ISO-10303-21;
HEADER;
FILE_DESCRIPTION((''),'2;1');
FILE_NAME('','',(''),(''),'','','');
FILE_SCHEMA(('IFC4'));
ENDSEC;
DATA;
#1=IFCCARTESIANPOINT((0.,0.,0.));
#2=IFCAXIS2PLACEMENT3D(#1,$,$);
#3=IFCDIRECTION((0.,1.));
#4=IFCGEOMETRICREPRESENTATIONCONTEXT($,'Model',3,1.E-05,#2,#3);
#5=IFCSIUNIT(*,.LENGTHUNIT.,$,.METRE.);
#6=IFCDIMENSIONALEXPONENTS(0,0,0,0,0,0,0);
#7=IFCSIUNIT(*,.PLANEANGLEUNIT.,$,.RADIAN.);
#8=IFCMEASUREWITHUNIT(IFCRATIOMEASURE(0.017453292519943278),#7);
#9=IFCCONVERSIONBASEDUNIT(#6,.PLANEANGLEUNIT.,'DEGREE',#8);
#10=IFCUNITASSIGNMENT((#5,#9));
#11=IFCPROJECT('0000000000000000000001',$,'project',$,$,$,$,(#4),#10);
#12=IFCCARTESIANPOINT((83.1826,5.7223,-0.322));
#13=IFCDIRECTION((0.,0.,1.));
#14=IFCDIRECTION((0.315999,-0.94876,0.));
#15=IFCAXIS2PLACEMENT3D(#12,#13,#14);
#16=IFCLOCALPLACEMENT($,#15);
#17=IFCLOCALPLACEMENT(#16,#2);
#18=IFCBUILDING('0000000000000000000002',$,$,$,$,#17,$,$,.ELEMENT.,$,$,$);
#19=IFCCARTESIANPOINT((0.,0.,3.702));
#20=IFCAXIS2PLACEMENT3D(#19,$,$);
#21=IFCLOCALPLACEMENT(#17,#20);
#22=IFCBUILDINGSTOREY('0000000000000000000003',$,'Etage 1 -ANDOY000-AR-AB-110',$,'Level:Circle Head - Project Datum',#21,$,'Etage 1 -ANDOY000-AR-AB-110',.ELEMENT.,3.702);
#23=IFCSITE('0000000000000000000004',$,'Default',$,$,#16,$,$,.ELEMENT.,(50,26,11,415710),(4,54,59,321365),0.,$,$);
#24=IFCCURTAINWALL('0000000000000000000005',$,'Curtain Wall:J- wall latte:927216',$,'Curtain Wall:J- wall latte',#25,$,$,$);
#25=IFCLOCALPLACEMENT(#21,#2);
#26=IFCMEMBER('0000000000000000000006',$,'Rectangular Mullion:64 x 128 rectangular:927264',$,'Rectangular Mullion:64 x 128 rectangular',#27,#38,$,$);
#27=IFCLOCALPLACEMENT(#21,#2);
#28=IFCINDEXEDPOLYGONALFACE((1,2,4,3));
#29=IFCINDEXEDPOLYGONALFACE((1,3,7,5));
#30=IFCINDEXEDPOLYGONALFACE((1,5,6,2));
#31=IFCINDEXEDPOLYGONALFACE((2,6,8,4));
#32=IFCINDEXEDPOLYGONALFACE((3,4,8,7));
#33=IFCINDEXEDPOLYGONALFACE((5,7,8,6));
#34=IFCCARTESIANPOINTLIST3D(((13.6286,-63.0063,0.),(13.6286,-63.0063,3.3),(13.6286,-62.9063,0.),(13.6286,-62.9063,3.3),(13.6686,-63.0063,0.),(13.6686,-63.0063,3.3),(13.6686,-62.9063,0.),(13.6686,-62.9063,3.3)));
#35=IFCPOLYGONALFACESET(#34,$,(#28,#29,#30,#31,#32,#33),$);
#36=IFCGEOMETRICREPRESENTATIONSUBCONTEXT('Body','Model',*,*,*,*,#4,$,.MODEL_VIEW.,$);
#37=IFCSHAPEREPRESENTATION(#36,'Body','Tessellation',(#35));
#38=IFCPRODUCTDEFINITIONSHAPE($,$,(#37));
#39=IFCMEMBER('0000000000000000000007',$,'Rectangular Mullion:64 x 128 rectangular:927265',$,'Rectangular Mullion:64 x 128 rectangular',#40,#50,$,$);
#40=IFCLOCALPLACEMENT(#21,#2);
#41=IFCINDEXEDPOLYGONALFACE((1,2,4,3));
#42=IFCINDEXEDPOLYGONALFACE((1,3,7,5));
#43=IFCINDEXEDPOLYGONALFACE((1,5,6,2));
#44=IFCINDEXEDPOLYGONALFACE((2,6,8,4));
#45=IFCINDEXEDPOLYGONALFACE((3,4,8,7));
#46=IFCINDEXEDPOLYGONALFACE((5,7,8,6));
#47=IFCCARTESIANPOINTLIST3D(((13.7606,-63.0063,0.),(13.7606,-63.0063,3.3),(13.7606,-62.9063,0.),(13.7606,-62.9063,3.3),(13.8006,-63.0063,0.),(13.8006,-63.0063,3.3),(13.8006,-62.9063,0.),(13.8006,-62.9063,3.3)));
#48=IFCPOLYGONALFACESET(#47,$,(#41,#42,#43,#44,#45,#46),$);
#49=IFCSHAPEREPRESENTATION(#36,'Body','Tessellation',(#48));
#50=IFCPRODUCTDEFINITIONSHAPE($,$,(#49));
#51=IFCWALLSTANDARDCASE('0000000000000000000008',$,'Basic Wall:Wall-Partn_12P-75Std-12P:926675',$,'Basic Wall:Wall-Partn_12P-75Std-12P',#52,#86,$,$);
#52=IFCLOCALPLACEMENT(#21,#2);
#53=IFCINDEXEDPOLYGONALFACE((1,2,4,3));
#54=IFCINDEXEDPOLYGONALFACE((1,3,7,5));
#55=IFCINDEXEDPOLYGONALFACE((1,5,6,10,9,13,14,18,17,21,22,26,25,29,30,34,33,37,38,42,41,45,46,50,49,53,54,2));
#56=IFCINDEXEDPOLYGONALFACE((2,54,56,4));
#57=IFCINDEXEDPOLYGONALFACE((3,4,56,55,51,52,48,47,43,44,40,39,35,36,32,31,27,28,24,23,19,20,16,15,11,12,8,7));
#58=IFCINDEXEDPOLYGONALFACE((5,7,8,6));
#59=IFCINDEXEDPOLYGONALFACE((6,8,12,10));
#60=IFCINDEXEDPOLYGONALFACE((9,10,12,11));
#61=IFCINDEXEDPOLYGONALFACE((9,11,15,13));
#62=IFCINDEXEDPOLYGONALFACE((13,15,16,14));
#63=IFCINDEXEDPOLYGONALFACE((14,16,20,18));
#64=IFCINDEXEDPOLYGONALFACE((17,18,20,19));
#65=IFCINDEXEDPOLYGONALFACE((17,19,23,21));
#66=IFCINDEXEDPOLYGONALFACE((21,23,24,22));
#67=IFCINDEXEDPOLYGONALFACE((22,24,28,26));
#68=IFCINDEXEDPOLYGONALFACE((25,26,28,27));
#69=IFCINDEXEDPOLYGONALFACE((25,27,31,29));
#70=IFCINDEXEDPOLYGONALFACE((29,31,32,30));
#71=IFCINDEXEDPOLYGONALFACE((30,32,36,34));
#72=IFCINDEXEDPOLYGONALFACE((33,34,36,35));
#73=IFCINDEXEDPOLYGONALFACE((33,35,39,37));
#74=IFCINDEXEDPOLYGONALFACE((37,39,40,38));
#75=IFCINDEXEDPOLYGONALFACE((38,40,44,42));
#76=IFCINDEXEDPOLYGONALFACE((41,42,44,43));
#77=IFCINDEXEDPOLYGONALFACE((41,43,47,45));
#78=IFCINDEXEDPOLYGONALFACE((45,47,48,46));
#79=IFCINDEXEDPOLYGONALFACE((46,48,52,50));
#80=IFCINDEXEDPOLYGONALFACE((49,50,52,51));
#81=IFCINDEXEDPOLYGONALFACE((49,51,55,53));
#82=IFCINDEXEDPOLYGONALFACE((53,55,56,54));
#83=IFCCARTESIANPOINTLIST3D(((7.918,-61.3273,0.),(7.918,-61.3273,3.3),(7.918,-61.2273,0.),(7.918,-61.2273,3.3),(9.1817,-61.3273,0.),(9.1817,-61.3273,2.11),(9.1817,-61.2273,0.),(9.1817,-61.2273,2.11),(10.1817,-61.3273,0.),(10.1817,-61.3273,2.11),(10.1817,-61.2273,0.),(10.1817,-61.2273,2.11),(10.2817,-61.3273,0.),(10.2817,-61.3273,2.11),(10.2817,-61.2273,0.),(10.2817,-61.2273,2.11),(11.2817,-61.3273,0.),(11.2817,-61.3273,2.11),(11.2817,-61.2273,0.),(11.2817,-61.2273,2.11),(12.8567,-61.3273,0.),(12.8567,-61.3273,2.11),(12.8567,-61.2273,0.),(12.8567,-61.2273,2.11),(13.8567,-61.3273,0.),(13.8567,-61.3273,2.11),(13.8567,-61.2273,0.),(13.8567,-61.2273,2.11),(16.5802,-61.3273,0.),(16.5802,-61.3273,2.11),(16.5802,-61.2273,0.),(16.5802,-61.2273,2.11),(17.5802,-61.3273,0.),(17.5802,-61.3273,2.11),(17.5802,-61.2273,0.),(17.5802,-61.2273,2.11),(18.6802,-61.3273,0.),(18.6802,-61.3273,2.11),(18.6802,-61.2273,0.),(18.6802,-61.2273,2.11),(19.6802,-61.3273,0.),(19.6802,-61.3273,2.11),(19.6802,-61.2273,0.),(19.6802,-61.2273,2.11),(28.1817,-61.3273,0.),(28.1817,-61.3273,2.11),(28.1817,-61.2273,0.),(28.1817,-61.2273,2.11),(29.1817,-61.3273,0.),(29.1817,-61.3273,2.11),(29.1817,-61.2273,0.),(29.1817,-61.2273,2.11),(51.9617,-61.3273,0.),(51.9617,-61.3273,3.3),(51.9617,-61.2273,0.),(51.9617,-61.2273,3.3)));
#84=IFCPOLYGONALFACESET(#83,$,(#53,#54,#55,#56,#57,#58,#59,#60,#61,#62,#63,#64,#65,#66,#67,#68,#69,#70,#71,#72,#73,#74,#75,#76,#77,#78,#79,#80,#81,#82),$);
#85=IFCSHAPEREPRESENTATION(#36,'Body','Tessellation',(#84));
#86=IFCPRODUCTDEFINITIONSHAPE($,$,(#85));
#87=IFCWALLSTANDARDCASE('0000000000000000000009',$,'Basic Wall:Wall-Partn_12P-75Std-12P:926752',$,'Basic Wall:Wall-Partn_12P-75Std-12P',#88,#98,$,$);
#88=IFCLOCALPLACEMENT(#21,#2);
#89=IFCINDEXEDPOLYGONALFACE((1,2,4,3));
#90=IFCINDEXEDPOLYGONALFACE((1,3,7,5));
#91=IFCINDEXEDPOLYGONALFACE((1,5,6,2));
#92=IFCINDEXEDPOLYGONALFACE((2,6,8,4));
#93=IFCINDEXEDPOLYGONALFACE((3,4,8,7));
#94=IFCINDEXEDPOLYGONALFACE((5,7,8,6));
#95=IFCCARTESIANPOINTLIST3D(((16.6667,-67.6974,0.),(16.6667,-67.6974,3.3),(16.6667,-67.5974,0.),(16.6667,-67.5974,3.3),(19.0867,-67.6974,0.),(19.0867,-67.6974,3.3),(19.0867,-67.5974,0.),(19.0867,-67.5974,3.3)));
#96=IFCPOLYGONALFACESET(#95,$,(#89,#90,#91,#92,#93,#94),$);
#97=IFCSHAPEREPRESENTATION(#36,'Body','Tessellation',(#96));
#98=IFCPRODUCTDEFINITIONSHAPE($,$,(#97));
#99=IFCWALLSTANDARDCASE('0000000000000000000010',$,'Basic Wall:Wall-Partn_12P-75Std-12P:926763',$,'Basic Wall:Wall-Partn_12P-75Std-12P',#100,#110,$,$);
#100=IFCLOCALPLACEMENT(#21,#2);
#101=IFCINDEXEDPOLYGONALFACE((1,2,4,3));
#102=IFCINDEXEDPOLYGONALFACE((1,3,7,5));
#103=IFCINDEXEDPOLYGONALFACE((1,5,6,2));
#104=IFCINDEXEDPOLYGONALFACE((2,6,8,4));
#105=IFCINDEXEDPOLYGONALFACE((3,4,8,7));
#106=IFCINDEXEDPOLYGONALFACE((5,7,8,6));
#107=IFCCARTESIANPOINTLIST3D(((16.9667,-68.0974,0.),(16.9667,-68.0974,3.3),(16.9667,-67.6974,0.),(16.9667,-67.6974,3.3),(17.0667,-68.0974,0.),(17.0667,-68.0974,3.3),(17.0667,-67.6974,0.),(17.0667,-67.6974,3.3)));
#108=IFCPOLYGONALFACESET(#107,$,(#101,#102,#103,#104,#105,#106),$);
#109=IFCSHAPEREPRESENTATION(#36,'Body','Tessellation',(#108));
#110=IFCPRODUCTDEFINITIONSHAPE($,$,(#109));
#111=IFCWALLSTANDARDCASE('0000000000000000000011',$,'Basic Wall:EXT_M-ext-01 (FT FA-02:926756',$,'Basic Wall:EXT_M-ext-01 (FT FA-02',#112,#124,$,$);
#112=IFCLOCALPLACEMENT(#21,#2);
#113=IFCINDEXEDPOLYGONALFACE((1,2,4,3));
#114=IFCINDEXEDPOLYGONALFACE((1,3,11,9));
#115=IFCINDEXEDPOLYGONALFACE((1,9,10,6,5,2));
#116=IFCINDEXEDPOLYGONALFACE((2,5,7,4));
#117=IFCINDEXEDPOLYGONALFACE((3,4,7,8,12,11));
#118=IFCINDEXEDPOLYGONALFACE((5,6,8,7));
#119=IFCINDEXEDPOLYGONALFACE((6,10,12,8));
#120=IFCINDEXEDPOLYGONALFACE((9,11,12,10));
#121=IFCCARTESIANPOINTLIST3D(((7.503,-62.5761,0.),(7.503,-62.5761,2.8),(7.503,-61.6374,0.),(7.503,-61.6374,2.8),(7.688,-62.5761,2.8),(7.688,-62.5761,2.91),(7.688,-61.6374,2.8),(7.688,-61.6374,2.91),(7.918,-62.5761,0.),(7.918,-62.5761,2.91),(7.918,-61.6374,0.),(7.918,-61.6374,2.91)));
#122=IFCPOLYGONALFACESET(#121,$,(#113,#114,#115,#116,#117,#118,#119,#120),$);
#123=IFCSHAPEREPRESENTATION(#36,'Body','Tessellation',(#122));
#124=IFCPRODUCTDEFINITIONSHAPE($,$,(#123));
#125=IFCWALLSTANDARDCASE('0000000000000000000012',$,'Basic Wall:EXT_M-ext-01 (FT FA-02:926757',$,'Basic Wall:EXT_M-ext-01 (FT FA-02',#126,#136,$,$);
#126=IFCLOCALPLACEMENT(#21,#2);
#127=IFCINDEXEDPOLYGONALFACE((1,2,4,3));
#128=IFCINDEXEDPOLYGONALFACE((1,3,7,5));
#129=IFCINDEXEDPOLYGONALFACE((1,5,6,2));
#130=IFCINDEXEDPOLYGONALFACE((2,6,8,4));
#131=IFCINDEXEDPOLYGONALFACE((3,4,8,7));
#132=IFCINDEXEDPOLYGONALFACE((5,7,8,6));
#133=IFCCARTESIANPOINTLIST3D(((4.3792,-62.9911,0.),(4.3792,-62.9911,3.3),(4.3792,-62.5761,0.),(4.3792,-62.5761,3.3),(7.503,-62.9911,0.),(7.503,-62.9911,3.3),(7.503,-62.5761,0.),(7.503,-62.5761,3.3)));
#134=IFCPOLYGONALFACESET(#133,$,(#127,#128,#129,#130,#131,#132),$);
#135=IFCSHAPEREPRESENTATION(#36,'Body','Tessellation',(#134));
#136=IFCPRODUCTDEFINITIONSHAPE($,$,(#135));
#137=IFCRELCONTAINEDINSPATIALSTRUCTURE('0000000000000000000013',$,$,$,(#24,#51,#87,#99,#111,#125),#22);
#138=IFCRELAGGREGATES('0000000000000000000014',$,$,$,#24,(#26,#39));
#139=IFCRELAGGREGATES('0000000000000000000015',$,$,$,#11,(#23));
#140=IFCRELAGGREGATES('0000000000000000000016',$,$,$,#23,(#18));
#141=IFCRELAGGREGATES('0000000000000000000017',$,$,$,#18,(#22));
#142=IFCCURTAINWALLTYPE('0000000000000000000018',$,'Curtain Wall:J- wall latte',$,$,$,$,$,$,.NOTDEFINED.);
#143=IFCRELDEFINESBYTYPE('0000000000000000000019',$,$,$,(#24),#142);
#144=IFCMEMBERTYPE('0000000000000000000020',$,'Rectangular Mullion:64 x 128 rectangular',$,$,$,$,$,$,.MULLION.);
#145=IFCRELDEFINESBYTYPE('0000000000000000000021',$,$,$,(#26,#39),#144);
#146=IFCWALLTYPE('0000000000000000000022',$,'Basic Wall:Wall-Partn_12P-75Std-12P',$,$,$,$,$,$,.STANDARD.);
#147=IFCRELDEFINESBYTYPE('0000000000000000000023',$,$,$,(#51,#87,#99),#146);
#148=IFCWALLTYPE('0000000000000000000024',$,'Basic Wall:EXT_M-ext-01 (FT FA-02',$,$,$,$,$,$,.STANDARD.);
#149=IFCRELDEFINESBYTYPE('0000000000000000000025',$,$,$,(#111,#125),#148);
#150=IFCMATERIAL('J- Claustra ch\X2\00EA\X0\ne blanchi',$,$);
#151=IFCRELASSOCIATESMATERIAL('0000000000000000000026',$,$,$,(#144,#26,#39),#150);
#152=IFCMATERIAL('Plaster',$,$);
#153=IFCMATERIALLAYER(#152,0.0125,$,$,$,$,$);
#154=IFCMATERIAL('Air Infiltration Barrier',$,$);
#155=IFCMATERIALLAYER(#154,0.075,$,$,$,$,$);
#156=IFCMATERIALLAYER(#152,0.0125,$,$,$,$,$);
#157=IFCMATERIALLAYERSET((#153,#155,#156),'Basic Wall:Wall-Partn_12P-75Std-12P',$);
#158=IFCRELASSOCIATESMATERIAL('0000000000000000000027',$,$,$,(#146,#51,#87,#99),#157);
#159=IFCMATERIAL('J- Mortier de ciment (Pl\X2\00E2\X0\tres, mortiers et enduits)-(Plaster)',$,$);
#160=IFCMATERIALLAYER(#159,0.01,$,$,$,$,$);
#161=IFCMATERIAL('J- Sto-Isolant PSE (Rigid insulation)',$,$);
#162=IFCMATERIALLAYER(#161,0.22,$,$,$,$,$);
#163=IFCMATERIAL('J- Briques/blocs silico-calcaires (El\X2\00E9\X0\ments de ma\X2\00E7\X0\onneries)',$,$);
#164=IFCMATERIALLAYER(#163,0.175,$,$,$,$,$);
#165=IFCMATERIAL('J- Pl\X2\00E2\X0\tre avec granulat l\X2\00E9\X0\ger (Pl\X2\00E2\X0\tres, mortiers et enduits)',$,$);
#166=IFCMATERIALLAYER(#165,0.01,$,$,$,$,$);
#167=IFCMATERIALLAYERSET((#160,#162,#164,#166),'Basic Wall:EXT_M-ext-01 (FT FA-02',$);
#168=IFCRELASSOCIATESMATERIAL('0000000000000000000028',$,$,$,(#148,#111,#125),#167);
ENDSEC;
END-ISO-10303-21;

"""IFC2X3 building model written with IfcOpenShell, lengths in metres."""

from ifc_helpers import new_model, entity, si_unit, converted_unit, direction, frame, frame_2d, origin, origin_2d_with_axis, place, context, subcontext, project, spatial, polyline, rectangle, extrude, clip, bounded_halfspace, source, transform, mapped, material, layer, layer_set, layer_usage, type_object, type_shapes, element, aggregate, save


model = new_model("IFC2X3")

# Units and contexts
model_context = context("Model", 3, precision=1e-05, world=origin(), true_north=direction((0.0, 1.0)))
body_context = subcontext(model_context, "Body", "Model", "MODEL_VIEW")
ifc_project = project(units=[si_unit("LENGTHUNIT", "METRE"), converted_unit("PLANEANGLEUNIT", "DEGREE", entity("IfcRatioMeasure", 0.017453292519943278), si_unit("PLANEANGLEUNIT", "RADIAN"), dimensions=[0, 0, 0, 0, 0, 0, 0])], contexts=[model_context])

# Site, building, storey
site_placement = place(None, frame((83.1826, 5.7223, -0.322), z_axis=(0.0, 0.0, 1.0), x_axis=(0.315999, -0.94876, 0.0)))
site = spatial("IfcSite", under=ifc_project, at=site_placement, Name="Default", CompositionType="ELEMENT", RefLatitude=(50, 26, 11, 415710), RefLongitude=(4, 54, 59, 321365), RefElevation=0.0)
building_placement = place(site_placement, origin())
building = spatial("IfcBuilding", under=site, at=building_placement, CompositionType="ELEMENT")
storey_placement = place(building_placement, frame((0.0, 0.0, 3.702)))
storey = spatial("IfcBuildingStorey", under=building, at=storey_placement, Name="Etage 1 -ANDOY000-AR-AB-110", ObjectType="Level:Circle Head - Project Datum", LongName="Etage 1 -ANDOY000-AR-AB-110", CompositionType="ELEMENT", Elevation=3.702)

# Curtain wall, members
curtain_wall_type = type_object("IfcCurtainWallType", Name="Curtain Wall:J- wall latte", PredefinedType="NOTDEFINED")
curtain_wall_placement = place(storey_placement, frame((0.0, 0.0, -3.702)))
curtain_wall = element("IfcCurtainWall", 1, at=curtain_wall_placement, inside=storey, type_object=curtain_wall_type, Name="Curtain Wall:J- wall latte:927216", ObjectType="Curtain Wall:J- wall latte")
ifc_material_1 = material(Name="J- Claustra chêne blanchi")
member_type = type_object("IfcMemberType", Name="Rectangular Mullion:64 x 128 rectangular", PredefinedType="MULLION", material=ifc_material_1)
shared_shape_1 = source(origin(), body_context, "Body", "SweptSolid", [
    extrude(rectangle(XDim=0.1, YDim=0.04, at=origin_2d_with_axis()), frame((0.0, 0.0, -3.3), z_axis=(0.0, 0.0, 1.0), x_axis=(0.0, -1.0, 0.0)), (0.0, 0.0, 1.0), 3.3),
])
type_shapes(member_type, [shared_shape_1])
member_1_placement = place(curtain_wall_placement, frame((13.6486, -62.9563, 3.702), z_axis=(0.0, 0.0, -1.0), x_axis=(1.0, 0.0, 0.0)))
member_1 = element("IfcMember", 2, at=member_1_placement, type_object=member_type, material=ifc_material_1, Name="Rectangular Mullion:64 x 128 rectangular:927264", ObjectType="Rectangular Mullion:64 x 128 rectangular", context=body_context, shape_type="MappedRepresentation", body=[
    mapped(shared_shape_1, transform((0.0, 0.0, 0.0), scale=1.0)),
])
member_2_placement = place(curtain_wall_placement, frame((13.7806, -62.9563, 3.702), z_axis=(0.0, 0.0, -1.0), x_axis=(1.0, 0.0, 0.0)))
member_2 = element("IfcMember", 3, at=member_2_placement, type_object=member_type, material=ifc_material_1, Name="Rectangular Mullion:64 x 128 rectangular:927265", ObjectType="Rectangular Mullion:64 x 128 rectangular", context=body_context, shape_type="MappedRepresentation", body=[
    mapped(shared_shape_1, transform((0.0, 0.0, 0.0), scale=1.0)),
])
aggregate(curtain_wall, [member_1, member_2])

# Wall, openings
ifc_material_2 = material(Name="Plaster")
ifc_layer_1 = layer(ifc_material_2, 0.0125)
ifc_material_3 = material(Name="Air Infiltration Barrier")
ifc_layer_2 = layer(ifc_material_3, 0.075)
ifc_layer_3 = layer(ifc_material_2, 0.0125)
ifc_layer_set_1 = layer_set([ifc_layer_1, ifc_layer_2, ifc_layer_3], Name="Basic Wall:Wall-Partn_12P-75Std-12P")
ifc_layer_usage_1 = layer_usage(ifc_layer_set_1, "AXIS2", "NEGATIVE", 0.05)
wall_type_1 = type_object("IfcWallType", Name="Basic Wall:Wall-Partn_12P-75Std-12P", PredefinedType="STANDARD", material=ifc_layer_set_1)
wall_1_placement = place(storey_placement, frame((7.918, -61.2773, 0.0)))
wall_1 = element("IfcWallStandardCase", 4, at=wall_1_placement, inside=storey, type_object=wall_type_1, material=ifc_layer_usage_1, Name="Basic Wall:Wall-Partn_12P-75Std-12P:926675", ObjectType="Basic Wall:Wall-Partn_12P-75Std-12P", context=body_context, shape_type="SweptSolid", body=[
    extrude(rectangle(XDim=44.0438, YDim=0.1, at=frame_2d((22.0219, 0.0), x_axis=(1.0, 0.0))), origin(), (0.0, 0.0, 1.0), 3.3),
])
opening_1_placement = place(wall_1_placement, frame((4.9387, -0.05, 0.0)))
element("IfcOpeningElement", 5, at=opening_1_placement, cuts=wall_1, ObjectType="Opening", context=body_context, shape_type="SweptSolid", body=[
    extrude(rectangle(XDim=2.11, YDim=1.0, at=frame_2d((1.055, 0.5), x_axis=(1.0, 0.0))), frame((0.0, 0.0, 0.0), z_axis=(0.0, 1.0, 0.0), x_axis=(0.0, 0.0, 1.0)), (0.0, 0.0, 1.0), 0.1),
])
opening_2_placement = place(wall_1_placement, frame((2.3637, -0.05, 0.0)))
element("IfcOpeningElement", 6, at=opening_2_placement, cuts=wall_1, ObjectType="Opening", context=body_context, shape_type="SweptSolid", body=[
    extrude(rectangle(XDim=2.11, YDim=1.0, at=frame_2d((1.055, 0.5), x_axis=(1.0, 0.0))), frame((0.0, 0.0, 0.0), z_axis=(0.0, 1.0, 0.0), x_axis=(0.0, 0.0, 1.0)), (0.0, 0.0, 1.0), 0.1),
])
opening_3_placement = place(wall_1_placement, frame((1.2637, -0.05, 0.0)))
element("IfcOpeningElement", 7, at=opening_3_placement, cuts=wall_1, ObjectType="Opening", context=body_context, shape_type="SweptSolid", body=[
    extrude(rectangle(XDim=2.11, YDim=1.0, at=frame_2d((1.055, 0.5), x_axis=(1.0, 0.0))), frame((0.0, 0.0, 0.0), z_axis=(0.0, 1.0, 0.0), x_axis=(0.0, 0.0, 1.0)), (0.0, 0.0, 1.0), 0.1),
])
opening_4_placement = place(wall_1_placement, frame((8.6623, -0.05, 0.0)))
element("IfcOpeningElement", 8, at=opening_4_placement, cuts=wall_1, ObjectType="Opening", context=body_context, shape_type="SweptSolid", body=[
    extrude(rectangle(XDim=2.11, YDim=1.0, at=frame_2d((1.055, 0.5), x_axis=(1.0, 0.0))), frame((0.0, 0.0, 0.0), z_axis=(0.0, 1.0, 0.0), x_axis=(0.0, 0.0, 1.0)), (0.0, 0.0, 1.0), 0.1),
])
opening_5_placement = place(wall_1_placement, frame((10.7623, -0.05, 0.0)))
element("IfcOpeningElement", 9, at=opening_5_placement, cuts=wall_1, ObjectType="Opening", context=body_context, shape_type="SweptSolid", body=[
    extrude(rectangle(XDim=2.11, YDim=1.0, at=frame_2d((1.055, 0.5), x_axis=(1.0, 0.0))), frame((0.0, 0.0, 0.0), z_axis=(0.0, 1.0, 0.0), x_axis=(0.0, 0.0, 1.0)), (0.0, 0.0, 1.0), 0.1),
])
opening_6_placement = place(wall_1_placement, frame((20.2637, -0.05, 0.0)))
element("IfcOpeningElement", 10, at=opening_6_placement, cuts=wall_1, ObjectType="Opening", context=body_context, shape_type="SweptSolid", body=[
    extrude(rectangle(XDim=2.11, YDim=1.0, at=frame_2d((1.055, 0.5), x_axis=(1.0, 0.0))), frame((0.0, 0.0, 0.0), z_axis=(0.0, 1.0, 0.0), x_axis=(0.0, 0.0, 1.0)), (0.0, 0.0, 1.0), 0.1),
])

# Wall
wall_2_placement = place(storey_placement, frame((16.6667, -67.6474, 0.0)))
element("IfcWallStandardCase", 11, at=wall_2_placement, inside=storey, type_object=wall_type_1, material=ifc_layer_usage_1, Name="Basic Wall:Wall-Partn_12P-75Std-12P:926752", ObjectType="Basic Wall:Wall-Partn_12P-75Std-12P", context=body_context, shape_type="SweptSolid", body=[
    extrude(rectangle(XDim=2.42, YDim=0.1, at=frame_2d((1.21, 0.0), x_axis=(-1.0, 0.0))), origin(), (0.0, 0.0, 1.0), 3.3),
])

# Walls
wall_3_placement = place(storey_placement, frame((17.0167, -67.6974, 0.0), z_axis=(0.0, 0.0, 1.0), x_axis=(0.0, -1.0, 0.0)))
element("IfcWallStandardCase", 12, at=wall_3_placement, inside=storey, type_object=wall_type_1, material=ifc_layer_usage_1, Name="Basic Wall:Wall-Partn_12P-75Std-12P:926763", ObjectType="Basic Wall:Wall-Partn_12P-75Std-12P", context=body_context, shape_type="SweptSolid", body=[
    extrude(rectangle(XDim=0.4, YDim=0.1, at=frame_2d((0.2, 0.0), x_axis=(-1.0, 0.0))), origin(), (0.0, 0.0, 1.0), 3.3),
])
ifc_material_4 = material(Name="J- Mortier de ciment (Plâtres, mortiers et enduits)-(Plaster)")
ifc_layer_4 = layer(ifc_material_4, 0.01)
ifc_material_5 = material(Name="J- Sto-Isolant PSE (Rigid insulation)")
ifc_layer_5 = layer(ifc_material_5, 0.22)
ifc_material_6 = material(Name="J- Briques/blocs silico-calcaires (Eléments de maçonneries)")
ifc_layer_6 = layer(ifc_material_6, 0.175)
ifc_material_7 = material(Name="J- Plâtre avec granulat léger (Plâtres, mortiers et enduits)")
ifc_layer_7 = layer(ifc_material_7, 0.01)
ifc_layer_set_2 = layer_set([ifc_layer_4, ifc_layer_5, ifc_layer_6, ifc_layer_7], Name="Basic Wall:EXT_M-ext-01 (FT FA-02")
ifc_layer_usage_2 = layer_usage(ifc_layer_set_2, "AXIS2", "NEGATIVE", 0.2075)
wall_type_2 = type_object("IfcWallType", Name="Basic Wall:EXT_M-ext-01 (FT FA-02", PredefinedType="STANDARD", material=ifc_layer_set_2)
wall_4_placement = place(storey_placement, frame((7.7105, -61.6374, 0.0), z_axis=(0.0, 0.0, 1.0), x_axis=(0.0, -1.0, 0.0)))
element("IfcWallStandardCase", 13, at=wall_4_placement, inside=storey, type_object=wall_type_2, material=ifc_layer_usage_2, Name="Basic Wall:EXT_M-ext-01 (FT FA-02:926756", ObjectType="Basic Wall:EXT_M-ext-01 (FT FA-02", context=body_context, shape_type="Clipping", body=[
    clip(clip(clip(extrude(rectangle(XDim=0.9387, YDim=0.415, at=frame_2d((0.4693, 0.0), x_axis=(-1.0, 0.0))), origin(), (0.0, 0.0, 1.0), 2.91), bounded_halfspace(frame((0.0, -0.2075, 2.8), z_axis=(0.0, 0.0, 1.0), x_axis=(0.0, 1.0, 0.0)), False, frame((0.0, -0.2075, 2.8), z_axis=(0.0, 0.0, 1.0), x_axis=(0.0, 1.0, 0.0)), polyline([(0.0, 0.0), (0.0, -0.9387), (0.185, -0.9387), (0.185, 0.0), (0.0, 0.0)]))), bounded_halfspace(frame((0.9387, -0.0225, 2.8), z_axis=(0.0, 1.0, 0.0), x_axis=(-1.0, 0.0, 0.0)), True, frame((0.9387, -0.0225, 2.8), z_axis=(0.0, 1.0, 0.0), x_axis=(-1.0, 0.0, 0.0)), polyline([(0.0, 0.0), (0.9387, 0.0), (0.9387, 0.11), (0.0, 0.11), (0.0, 0.0)]))), bounded_halfspace(frame((0.9387, 0.2075, 2.91), z_axis=(0.0, 0.0, -1.0), x_axis=(0.0, 1.0, 0.0)), True, frame((0.9387, 0.2075, 2.91), z_axis=(0.0, 0.0, -1.0), x_axis=(0.0, 1.0, 0.0)), polyline([(0.0, 0.0), (-0.23, 0.0), (-0.23, -0.9387), (0.0, -0.9387), (0.0, 0.0)]))),
])
wall_5_placement = place(storey_placement, frame((7.503, -62.7836, 0.0), z_axis=(0.0, 0.0, 1.0), x_axis=(-1.0, -0.000003, 0.0)))
element("IfcWallStandardCase", 14, at=wall_5_placement, inside=storey, type_object=wall_type_2, material=ifc_layer_usage_2, Name="Basic Wall:EXT_M-ext-01 (FT FA-02:926757", ObjectType="Basic Wall:EXT_M-ext-01 (FT FA-02", context=body_context, shape_type="SweptSolid", body=[
    extrude(rectangle(XDim=3.1237, YDim=0.415, at=frame_2d((1.5619, 0.0), x_axis=(-1.0, 0.0))), origin(), (0.0, 0.0, 1.0), 3.3),
])

save(model, "model.ifc")
